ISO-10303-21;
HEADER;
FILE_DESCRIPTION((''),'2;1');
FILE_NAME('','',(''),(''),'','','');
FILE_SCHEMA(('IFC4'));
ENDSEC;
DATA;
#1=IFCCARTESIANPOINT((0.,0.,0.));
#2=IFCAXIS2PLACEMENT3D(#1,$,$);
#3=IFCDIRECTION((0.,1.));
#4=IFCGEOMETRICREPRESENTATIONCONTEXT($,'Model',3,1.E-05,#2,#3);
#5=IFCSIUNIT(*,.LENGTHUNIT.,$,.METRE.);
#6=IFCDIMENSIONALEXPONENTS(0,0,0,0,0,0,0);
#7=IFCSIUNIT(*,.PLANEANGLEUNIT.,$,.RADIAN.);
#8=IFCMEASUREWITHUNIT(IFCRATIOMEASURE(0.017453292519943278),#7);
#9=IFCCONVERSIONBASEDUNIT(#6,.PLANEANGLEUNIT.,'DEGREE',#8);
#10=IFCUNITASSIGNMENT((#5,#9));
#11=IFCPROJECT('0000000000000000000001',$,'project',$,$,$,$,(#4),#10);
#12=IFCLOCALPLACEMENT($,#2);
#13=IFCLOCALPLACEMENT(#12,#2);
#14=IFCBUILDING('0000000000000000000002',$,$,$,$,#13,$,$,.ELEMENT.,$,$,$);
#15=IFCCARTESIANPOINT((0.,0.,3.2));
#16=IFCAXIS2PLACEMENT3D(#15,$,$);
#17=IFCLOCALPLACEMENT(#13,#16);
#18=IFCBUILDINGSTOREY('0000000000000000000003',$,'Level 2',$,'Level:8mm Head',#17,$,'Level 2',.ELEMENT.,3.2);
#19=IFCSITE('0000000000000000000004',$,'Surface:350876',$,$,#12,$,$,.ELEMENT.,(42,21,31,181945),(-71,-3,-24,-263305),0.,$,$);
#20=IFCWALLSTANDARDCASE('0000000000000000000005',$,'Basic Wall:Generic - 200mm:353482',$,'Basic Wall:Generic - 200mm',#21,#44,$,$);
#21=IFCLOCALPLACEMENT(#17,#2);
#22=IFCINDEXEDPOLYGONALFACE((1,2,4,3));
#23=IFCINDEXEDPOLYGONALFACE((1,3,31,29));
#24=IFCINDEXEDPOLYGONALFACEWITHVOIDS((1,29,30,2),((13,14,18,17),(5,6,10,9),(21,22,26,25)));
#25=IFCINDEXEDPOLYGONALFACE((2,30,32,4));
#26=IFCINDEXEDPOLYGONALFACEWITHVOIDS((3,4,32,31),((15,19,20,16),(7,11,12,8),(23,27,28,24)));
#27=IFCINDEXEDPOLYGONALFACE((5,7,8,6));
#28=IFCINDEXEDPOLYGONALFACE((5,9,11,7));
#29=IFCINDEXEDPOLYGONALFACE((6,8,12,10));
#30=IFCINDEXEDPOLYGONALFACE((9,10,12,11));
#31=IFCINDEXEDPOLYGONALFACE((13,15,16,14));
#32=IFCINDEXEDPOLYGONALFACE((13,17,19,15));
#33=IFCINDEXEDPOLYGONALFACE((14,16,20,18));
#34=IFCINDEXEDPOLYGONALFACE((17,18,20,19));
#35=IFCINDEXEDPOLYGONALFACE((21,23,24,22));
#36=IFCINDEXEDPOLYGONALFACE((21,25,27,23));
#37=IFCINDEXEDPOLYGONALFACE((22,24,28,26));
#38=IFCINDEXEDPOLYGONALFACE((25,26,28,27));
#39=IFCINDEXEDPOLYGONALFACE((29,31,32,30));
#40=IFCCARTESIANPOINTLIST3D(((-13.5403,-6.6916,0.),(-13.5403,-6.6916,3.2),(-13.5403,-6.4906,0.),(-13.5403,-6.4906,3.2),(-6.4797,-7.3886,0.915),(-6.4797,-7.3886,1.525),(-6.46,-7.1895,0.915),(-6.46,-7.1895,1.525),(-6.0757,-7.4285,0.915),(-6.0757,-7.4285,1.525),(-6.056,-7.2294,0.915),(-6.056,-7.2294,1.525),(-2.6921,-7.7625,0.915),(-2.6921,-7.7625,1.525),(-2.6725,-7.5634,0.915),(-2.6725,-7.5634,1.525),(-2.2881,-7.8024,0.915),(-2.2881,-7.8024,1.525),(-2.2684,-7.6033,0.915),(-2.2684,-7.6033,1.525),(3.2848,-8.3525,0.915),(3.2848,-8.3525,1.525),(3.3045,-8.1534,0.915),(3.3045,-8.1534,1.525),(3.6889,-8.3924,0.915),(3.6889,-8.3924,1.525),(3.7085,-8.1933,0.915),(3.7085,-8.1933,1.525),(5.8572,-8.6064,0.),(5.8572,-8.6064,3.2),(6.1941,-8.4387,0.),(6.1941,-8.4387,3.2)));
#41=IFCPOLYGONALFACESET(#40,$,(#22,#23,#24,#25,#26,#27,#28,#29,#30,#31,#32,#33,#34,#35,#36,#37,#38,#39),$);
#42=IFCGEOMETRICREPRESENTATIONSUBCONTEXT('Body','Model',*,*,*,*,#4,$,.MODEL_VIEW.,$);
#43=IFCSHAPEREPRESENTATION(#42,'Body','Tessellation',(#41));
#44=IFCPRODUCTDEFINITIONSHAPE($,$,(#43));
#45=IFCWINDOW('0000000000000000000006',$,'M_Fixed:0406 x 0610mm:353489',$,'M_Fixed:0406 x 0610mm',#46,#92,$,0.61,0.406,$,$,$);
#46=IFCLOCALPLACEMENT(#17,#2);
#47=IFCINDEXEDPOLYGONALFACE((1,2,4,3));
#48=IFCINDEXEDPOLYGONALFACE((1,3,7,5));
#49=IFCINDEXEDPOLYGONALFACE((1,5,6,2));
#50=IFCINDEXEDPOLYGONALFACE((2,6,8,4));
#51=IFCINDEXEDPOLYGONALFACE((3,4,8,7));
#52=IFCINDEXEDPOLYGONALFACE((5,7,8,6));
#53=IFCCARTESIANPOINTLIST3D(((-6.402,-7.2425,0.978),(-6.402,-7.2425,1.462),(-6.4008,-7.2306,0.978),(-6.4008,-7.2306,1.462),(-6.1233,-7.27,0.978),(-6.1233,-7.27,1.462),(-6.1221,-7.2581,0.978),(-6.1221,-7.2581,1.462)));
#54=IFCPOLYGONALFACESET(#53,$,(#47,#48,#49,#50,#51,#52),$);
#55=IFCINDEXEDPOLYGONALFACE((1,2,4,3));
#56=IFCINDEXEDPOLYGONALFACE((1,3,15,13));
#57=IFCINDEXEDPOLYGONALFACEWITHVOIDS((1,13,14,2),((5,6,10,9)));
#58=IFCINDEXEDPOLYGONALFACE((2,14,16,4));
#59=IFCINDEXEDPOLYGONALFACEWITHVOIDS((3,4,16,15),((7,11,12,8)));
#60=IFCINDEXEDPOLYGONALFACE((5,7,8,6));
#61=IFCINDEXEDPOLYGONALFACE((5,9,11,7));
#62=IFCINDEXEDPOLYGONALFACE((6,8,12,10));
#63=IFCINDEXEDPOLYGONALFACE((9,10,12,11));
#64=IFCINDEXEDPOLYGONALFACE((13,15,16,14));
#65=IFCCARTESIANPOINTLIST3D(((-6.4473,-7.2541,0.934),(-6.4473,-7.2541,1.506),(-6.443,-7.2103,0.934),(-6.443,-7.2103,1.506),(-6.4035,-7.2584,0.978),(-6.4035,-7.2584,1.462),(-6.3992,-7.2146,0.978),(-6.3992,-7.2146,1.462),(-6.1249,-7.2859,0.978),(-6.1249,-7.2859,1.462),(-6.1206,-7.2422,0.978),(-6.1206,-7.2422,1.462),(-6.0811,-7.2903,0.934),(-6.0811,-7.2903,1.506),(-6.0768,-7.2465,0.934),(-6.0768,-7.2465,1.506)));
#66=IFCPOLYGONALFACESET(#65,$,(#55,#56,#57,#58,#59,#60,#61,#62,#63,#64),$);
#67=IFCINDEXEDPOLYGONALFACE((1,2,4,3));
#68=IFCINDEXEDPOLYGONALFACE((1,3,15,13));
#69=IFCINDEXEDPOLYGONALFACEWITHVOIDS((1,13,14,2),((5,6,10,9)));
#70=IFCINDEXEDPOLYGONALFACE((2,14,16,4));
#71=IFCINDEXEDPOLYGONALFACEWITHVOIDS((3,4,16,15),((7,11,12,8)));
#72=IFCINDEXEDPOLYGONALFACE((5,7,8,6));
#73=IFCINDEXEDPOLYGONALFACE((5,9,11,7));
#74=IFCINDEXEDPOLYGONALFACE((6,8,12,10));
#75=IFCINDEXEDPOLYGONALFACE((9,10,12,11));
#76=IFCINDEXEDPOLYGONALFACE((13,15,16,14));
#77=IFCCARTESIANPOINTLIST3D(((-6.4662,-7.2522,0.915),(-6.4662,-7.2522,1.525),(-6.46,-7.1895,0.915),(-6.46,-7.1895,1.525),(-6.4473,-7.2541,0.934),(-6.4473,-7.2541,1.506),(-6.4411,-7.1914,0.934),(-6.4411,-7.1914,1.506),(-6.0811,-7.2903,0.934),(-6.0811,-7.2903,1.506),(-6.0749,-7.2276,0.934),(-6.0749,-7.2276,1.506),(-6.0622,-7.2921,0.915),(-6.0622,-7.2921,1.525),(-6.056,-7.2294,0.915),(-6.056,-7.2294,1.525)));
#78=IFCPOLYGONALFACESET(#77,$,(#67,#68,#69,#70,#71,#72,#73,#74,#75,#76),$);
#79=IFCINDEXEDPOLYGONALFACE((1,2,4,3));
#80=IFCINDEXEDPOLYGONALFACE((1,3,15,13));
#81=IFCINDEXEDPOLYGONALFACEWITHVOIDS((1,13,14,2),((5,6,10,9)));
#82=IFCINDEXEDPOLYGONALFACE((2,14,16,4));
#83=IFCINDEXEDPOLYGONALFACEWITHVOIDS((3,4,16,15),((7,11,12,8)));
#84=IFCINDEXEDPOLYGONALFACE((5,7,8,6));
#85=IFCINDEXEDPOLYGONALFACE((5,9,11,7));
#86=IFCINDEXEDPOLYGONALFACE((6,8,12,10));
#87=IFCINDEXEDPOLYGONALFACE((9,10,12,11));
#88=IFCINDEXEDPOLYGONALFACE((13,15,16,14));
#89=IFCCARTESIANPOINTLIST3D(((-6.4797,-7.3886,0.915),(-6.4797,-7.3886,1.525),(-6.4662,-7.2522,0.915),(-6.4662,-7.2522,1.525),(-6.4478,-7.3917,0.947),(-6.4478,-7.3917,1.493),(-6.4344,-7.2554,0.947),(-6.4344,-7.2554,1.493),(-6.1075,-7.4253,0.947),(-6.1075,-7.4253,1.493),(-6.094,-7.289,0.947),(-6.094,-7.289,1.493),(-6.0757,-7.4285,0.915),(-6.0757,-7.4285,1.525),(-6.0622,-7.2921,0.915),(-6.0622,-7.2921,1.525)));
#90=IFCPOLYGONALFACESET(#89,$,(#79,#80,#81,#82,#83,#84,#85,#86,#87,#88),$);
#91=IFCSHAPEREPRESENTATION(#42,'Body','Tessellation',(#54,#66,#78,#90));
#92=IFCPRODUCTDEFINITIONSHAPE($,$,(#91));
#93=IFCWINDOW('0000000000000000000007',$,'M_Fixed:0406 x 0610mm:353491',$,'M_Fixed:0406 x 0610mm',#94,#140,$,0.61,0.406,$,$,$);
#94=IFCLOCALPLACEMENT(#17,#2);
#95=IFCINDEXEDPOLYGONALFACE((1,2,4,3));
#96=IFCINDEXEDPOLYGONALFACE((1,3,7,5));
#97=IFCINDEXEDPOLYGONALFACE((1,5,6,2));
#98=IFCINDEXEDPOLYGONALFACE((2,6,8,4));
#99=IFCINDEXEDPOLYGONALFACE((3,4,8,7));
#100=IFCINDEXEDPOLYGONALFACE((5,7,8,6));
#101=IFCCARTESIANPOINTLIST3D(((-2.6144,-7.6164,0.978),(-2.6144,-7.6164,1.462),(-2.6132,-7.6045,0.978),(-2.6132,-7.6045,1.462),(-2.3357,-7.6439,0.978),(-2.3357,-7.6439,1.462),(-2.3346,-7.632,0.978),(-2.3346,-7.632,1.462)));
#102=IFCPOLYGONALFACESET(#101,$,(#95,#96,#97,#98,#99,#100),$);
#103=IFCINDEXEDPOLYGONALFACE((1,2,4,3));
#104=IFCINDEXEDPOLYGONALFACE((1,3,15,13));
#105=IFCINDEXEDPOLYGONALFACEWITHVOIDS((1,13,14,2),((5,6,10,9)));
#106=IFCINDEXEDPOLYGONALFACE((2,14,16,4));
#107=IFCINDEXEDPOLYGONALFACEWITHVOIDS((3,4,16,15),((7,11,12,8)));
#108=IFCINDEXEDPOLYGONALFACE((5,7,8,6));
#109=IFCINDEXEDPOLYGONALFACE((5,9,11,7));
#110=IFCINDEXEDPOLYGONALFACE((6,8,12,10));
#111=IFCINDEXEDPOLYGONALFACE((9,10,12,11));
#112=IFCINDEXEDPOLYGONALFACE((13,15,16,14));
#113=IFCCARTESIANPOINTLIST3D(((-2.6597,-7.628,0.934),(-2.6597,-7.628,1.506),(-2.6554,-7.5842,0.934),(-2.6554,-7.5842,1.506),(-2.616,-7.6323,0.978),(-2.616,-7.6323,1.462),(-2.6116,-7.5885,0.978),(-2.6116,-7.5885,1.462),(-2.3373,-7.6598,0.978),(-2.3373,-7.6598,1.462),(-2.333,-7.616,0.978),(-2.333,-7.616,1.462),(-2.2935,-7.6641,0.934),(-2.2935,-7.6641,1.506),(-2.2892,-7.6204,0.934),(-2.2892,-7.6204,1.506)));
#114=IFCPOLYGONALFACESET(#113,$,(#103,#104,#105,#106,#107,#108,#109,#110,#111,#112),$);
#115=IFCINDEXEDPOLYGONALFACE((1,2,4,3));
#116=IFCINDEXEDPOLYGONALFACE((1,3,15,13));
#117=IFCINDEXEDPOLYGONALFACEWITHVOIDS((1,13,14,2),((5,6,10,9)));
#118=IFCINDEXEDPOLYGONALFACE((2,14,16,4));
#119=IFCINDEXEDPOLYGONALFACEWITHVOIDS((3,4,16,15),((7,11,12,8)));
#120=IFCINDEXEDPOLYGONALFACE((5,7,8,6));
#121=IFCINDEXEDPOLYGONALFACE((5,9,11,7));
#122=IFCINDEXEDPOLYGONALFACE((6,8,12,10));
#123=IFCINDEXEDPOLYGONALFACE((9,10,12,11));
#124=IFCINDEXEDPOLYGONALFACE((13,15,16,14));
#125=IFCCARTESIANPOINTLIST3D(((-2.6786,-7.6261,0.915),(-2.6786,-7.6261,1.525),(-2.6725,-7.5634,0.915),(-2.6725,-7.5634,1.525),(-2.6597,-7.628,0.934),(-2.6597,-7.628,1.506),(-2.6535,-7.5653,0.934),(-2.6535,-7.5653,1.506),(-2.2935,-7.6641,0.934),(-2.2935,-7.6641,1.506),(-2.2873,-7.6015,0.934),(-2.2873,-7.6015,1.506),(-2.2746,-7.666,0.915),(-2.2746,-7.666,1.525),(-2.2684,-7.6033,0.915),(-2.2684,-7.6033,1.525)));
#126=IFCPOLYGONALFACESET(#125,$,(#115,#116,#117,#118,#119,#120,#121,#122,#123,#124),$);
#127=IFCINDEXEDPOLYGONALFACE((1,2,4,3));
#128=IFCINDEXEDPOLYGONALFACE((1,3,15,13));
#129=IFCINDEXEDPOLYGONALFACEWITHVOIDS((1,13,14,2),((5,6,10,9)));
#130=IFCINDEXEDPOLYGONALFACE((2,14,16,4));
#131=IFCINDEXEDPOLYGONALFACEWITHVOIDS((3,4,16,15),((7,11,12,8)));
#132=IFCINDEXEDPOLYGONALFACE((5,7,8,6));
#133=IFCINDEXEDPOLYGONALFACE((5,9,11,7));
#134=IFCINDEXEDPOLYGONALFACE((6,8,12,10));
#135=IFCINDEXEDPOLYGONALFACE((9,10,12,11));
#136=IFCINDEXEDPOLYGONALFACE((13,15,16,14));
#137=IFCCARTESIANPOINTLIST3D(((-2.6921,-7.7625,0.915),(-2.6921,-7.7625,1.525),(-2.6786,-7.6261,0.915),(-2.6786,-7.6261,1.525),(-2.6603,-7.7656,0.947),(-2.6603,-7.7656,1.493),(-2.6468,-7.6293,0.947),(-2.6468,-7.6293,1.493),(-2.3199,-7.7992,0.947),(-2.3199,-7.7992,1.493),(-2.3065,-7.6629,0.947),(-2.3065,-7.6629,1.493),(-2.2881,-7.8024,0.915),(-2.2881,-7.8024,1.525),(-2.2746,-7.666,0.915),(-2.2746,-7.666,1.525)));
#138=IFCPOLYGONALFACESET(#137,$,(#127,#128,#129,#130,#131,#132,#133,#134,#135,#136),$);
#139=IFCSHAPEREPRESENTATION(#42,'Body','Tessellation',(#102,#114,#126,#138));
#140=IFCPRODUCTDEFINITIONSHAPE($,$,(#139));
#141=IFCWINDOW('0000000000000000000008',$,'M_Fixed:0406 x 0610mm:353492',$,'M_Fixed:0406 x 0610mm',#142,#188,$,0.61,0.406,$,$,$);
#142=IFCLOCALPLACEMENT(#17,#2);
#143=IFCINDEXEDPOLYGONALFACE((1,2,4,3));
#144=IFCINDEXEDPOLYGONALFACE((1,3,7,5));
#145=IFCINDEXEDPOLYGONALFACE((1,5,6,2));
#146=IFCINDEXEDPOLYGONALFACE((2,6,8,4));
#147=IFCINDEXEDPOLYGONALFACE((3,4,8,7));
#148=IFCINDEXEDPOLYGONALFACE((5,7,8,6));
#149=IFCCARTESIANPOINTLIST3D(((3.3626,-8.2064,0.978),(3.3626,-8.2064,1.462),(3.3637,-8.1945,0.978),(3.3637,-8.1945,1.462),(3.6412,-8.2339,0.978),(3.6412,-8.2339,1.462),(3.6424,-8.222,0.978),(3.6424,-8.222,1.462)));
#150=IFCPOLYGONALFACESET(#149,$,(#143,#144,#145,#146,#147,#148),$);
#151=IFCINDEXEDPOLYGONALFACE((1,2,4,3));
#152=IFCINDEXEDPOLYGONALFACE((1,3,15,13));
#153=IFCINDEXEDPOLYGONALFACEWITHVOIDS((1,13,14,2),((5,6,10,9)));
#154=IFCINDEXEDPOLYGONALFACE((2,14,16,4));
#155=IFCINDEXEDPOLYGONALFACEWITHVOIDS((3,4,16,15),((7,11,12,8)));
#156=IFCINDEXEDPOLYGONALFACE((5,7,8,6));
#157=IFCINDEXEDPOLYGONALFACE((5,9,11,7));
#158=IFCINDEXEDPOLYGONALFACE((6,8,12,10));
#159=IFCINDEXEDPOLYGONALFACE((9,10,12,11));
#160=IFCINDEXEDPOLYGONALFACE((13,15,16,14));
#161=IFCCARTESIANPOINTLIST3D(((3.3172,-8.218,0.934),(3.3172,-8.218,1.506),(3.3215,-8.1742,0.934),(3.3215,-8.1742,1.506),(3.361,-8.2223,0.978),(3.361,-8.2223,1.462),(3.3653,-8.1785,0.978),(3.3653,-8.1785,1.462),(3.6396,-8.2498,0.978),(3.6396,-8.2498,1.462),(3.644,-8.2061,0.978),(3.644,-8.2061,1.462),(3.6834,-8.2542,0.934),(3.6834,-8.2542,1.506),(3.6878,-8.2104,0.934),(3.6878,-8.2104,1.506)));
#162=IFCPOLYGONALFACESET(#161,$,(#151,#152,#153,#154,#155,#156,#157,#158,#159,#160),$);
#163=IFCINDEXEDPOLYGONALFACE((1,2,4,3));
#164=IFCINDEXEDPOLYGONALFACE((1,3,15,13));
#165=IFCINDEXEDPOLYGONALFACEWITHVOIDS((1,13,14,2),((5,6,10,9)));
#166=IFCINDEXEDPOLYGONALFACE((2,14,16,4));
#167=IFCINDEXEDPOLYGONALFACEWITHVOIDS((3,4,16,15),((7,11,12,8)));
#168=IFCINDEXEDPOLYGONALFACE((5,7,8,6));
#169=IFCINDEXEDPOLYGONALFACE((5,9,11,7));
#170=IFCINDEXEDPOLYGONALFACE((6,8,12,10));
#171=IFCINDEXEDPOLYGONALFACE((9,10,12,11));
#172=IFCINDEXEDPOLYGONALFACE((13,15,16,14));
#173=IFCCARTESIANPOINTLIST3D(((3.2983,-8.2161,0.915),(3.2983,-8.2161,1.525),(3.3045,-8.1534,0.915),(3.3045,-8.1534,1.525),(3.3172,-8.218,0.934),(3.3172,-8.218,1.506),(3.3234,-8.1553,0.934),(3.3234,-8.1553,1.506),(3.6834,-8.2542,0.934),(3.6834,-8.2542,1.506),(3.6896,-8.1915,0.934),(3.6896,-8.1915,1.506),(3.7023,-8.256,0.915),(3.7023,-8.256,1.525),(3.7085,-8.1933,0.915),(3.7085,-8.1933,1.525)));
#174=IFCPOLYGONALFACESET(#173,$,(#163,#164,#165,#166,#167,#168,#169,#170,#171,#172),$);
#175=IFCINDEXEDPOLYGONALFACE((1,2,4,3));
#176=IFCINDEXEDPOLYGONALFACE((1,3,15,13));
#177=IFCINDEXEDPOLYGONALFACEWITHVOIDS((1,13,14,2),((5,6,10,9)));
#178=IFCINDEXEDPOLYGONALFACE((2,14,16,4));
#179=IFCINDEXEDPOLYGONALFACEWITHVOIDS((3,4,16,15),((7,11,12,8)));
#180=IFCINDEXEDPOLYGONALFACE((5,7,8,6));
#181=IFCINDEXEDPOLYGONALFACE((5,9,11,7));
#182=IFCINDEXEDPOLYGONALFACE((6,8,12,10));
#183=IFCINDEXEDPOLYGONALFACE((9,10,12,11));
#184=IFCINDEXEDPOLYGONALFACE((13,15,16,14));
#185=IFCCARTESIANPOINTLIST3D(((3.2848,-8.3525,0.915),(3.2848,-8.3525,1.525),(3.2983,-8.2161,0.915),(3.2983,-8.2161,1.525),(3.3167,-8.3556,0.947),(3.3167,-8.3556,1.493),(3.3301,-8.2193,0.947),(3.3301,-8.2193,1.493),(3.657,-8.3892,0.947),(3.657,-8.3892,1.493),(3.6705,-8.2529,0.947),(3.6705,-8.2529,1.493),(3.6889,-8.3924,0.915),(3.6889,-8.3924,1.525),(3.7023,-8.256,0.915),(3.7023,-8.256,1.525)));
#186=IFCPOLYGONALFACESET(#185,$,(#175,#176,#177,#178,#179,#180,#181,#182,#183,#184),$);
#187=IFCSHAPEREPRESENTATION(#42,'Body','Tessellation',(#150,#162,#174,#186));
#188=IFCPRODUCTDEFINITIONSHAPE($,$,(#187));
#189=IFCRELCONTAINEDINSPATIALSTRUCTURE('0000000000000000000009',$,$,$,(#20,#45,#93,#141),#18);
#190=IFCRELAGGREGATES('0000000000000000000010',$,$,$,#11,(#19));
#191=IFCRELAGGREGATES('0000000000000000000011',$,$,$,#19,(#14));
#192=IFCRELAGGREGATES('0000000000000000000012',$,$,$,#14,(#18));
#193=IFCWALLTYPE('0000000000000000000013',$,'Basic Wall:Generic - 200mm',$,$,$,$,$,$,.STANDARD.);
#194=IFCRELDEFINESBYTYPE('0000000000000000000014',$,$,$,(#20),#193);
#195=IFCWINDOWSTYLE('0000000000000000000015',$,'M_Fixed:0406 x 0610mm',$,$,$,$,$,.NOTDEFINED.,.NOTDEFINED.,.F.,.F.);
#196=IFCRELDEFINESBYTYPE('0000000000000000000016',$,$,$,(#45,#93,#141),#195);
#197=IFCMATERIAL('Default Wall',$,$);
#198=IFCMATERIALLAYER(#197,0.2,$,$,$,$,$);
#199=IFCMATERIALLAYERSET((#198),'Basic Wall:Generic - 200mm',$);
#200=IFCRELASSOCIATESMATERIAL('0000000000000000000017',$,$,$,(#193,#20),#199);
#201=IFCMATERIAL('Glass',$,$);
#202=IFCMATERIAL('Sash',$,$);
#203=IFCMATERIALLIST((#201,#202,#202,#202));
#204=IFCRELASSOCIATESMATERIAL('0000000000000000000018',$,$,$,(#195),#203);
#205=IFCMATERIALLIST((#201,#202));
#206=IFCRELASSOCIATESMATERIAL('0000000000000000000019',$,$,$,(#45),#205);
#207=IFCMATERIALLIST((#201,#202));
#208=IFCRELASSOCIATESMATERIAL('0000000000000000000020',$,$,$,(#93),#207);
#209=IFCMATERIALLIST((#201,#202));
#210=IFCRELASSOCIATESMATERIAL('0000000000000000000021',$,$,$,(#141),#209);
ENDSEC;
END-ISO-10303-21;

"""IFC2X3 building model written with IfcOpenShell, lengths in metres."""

from ifc_helpers import new_model, entity, si_unit, converted_unit, direction, frame, frame_2d, origin, place, context, subcontext, project, spatial, polyline, rectangle, outline, extrude, source, transform, mapped, material, material_list, layer, layer_set, layer_usage, type_object, type_shapes, element, fill, save


model = new_model("IFC2X3")

# Units and contexts
model_context = context("Model", 3, precision=1e-05, world=origin(), true_north=direction((0.0, 1.0)))
body_context = subcontext(model_context, "Body", "Model", "MODEL_VIEW")
ifc_project = project(units=[si_unit("LENGTHUNIT", "METRE"), converted_unit("PLANEANGLEUNIT", "DEGREE", entity("IfcRatioMeasure", 0.017453292519943278), si_unit("PLANEANGLEUNIT", "RADIAN"), dimensions=[0, 0, 0, 0, 0, 0, 0])], contexts=[model_context])

# Site, building, storey
site_placement = place(None, origin())
site = spatial("IfcSite", under=ifc_project, at=site_placement, Name="Surface:350876", CompositionType="ELEMENT", RefLatitude=(42, 21, 31, 181945), RefLongitude=(-71, -3, -24, -263305), RefElevation=0.0)
building_placement = place(site_placement, origin())
building = spatial("IfcBuilding", under=site, at=building_placement, CompositionType="ELEMENT")
storey_placement = place(building_placement, frame((0.0, 0.0, 3.2)))
storey = spatial("IfcBuildingStorey", under=building, at=storey_placement, Name="Level 2", ObjectType="Level:8mm Head", LongName="Level 2", CompositionType="ELEMENT", Elevation=3.2)

# Wall, openings, windows
ifc_material_1 = material(Name="Default Wall")
ifc_layer_1 = layer(ifc_material_1, 0.2)
ifc_layer_set_1 = layer_set([ifc_layer_1], Name="Basic Wall:Generic - 200mm")
ifc_layer_usage_1 = layer_usage(ifc_layer_set_1, "AXIS2", "NEGATIVE", 0.1)
wall_type_1 = type_object("IfcWallType", Name="Basic Wall:Generic - 200mm", PredefinedType="STANDARD", material=ifc_layer_set_1)
wall_1_placement = place(storey_placement, frame((-13.5501, -6.5901, 0.0), z_axis=(0.0, 0.0, 1.0), x_axis=(0.995163, -0.098237, 0.0)))
wall_1 = element("IfcWallStandardCase", 1, at=wall_1_placement, inside=storey, type_object=wall_type_1, material=ifc_layer_usage_1, Name="Basic Wall:Generic - 200mm:353482", ObjectType="Basic Wall:Generic - 200mm", context=body_context, shape_type="SweptSolid", body=[
    extrude(outline(polyline([(19.5116, -0.1), (19.8304, 0.1), (19.454, 0.1), (19.4098, 0.1), (9.0268, 0.1), (8.8258, 0.1), (2.0303, 0.1), (1.8239, 0.1), (0.0, 0.1), (0.0197, -0.1), (19.5116, -0.1)])), origin(), (0.0, 0.0, 1.0), 3.2),
])
opening_1_placement = place(wall_1_placement, frame((7.1147, -0.1, 0.915)))
opening_1 = element("IfcOpeningElement", 2, at=opening_1_placement, cuts=wall_1, ObjectType="Opening", context=body_context, shape_type="SweptSolid", body=[
    extrude(rectangle(XDim=0.61, YDim=0.406, at=frame_2d((0.305, 0.203), x_axis=(1.0, 0.0))), frame((0.0, 0.0, 0.0), z_axis=(0.0, 1.0, 0.0), x_axis=(0.0, 0.0, 1.0)), (0.0, 0.0, 1.0), 0.2),
])
opening_2_placement = place(wall_1_placement, frame((10.9207, -0.1, 0.915)))
opening_2 = element("IfcOpeningElement", 3, at=opening_2_placement, cuts=wall_1, ObjectType="Opening", context=body_context, shape_type="SweptSolid", body=[
    extrude(rectangle(XDim=0.61, YDim=0.406, at=frame_2d((0.305, 0.203), x_axis=(1.0, 0.0))), frame((0.0, 0.0, 0.0), z_axis=(0.0, 1.0, 0.0), x_axis=(0.0, 0.0, 1.0)), (0.0, 0.0, 1.0), 0.2),
])
opening_3_placement = place(wall_1_placement, frame((16.9267, -0.1, 0.915)))
opening_3 = element("IfcOpeningElement", 4, at=opening_3_placement, cuts=wall_1, ObjectType="Opening", context=body_context, shape_type="SweptSolid", body=[
    extrude(rectangle(XDim=0.61, YDim=0.406, at=frame_2d((0.305, 0.203), x_axis=(1.0, 0.0))), frame((0.0, 0.0, 0.0), z_axis=(0.0, 1.0, 0.0), x_axis=(0.0, 0.0, 1.0)), (0.0, 0.0, 1.0), 0.2),
])
ifc_material_2 = material(Name="Glass")
ifc_material_3 = material(Name="Sash")
ifc_material_list_1 = material_list([ifc_material_2, ifc_material_3])
ifc_material_list_2 = material_list([ifc_material_2, ifc_material_3, ifc_material_3, ifc_material_3])
window_style = type_object("IfcWindowStyle", Name="M_Fixed:0406 x 0610mm", ConstructionType="NOTDEFINED", OperationType="NOTDEFINED", ParameterTakesPrecedence=False, Sizeable=False, material=ifc_material_list_2)
shared_shape = source(origin(), body_context, "Body", "SweptSolid", [
    extrude(rectangle(XDim=0.012, YDim=0.28, at=frame_2d((0.0, 0.0), x_axis=(1.0, 0.0))), frame((0.203, 0.159, 0.063), z_axis=(0.0, 0.0, 1.0), x_axis=(0.0, -1.0, 0.0)), (0.0, 0.0, 1.0), 0.484),
    extrude(outline(polyline([(-0.184, -0.286), (0.184, -0.286), (0.184, 0.286), (-0.184, 0.286), (-0.184, -0.286)]), holes=[polyline([(-0.14, -0.242), (-0.14, 0.242), (0.14, 0.242), (0.14, -0.242), (-0.14, -0.242)])]), frame((0.203, 0.137, 0.305), z_axis=(0.0, 1.0, 0.0), x_axis=(1.0, 0.0, 0.0)), (0.0, 0.0, 1.0), 0.044),
    extrude(outline(polyline([(-0.203, -0.305), (0.203, -0.305), (0.203, 0.305), (-0.203, 0.305), (-0.203, -0.305)]), holes=[polyline([(-0.184, -0.286), (-0.184, 0.286), (0.184, 0.286), (0.184, -0.286), (-0.184, -0.286)])]), frame((0.203, 0.137, 0.305), z_axis=(0.0, 1.0, 0.0), x_axis=(1.0, 0.0, 0.0)), (0.0, 0.0, 1.0), 0.063),
    extrude(outline(polyline([(-0.203, -0.305), (0.203, -0.305), (0.203, 0.305), (-0.203, 0.305), (-0.203, -0.305)]), holes=[polyline([(-0.171, -0.273), (-0.171, 0.273), (0.171, 0.273), (0.171, -0.273), (-0.171, -0.273)])]), frame((0.203, 0.0, 0.305), z_axis=(0.0, 1.0, 0.0), x_axis=(1.0, 0.0, 0.0)), (0.0, 0.0, 1.0), 0.137),
])
type_shapes(window_style, [shared_shape])
window_1_placement = place(opening_1_placement, origin())
window_1 = element("IfcWindow", 5, at=window_1_placement, inside=storey, type_object=window_style, material=ifc_material_list_1, Name="M_Fixed:0406 x 0610mm:353489", ObjectType="M_Fixed:0406 x 0610mm", OverallHeight=0.61, OverallWidth=0.406, context=body_context, shape_type="MappedRepresentation", body=[
    mapped(shared_shape, transform((0.0, 0.0, 0.0), scale=1.0)),
])
fill(opening_1, window_1)
ifc_material_list_3 = material_list([ifc_material_2, ifc_material_3])
window_2_placement = place(opening_2_placement, origin())
window_2 = element("IfcWindow", 6, at=window_2_placement, inside=storey, type_object=window_style, material=ifc_material_list_3, Name="M_Fixed:0406 x 0610mm:353491", ObjectType="M_Fixed:0406 x 0610mm", OverallHeight=0.61, OverallWidth=0.406, context=body_context, shape_type="MappedRepresentation", body=[
    mapped(shared_shape, transform((0.0, 0.0, 0.0), scale=1.0)),
])
fill(opening_2, window_2)
ifc_material_list_4 = material_list([ifc_material_2, ifc_material_3])
window_3_placement = place(opening_3_placement, origin())
window_3 = element("IfcWindow", 7, at=window_3_placement, inside=storey, type_object=window_style, material=ifc_material_list_4, Name="M_Fixed:0406 x 0610mm:353492", ObjectType="M_Fixed:0406 x 0610mm", OverallHeight=0.61, OverallWidth=0.406, context=body_context, shape_type="MappedRepresentation", body=[
    mapped(shared_shape, transform((0.0, 0.0, 0.0), scale=1.0)),
])
fill(opening_3, window_3)

save(model, "model.ifc")
